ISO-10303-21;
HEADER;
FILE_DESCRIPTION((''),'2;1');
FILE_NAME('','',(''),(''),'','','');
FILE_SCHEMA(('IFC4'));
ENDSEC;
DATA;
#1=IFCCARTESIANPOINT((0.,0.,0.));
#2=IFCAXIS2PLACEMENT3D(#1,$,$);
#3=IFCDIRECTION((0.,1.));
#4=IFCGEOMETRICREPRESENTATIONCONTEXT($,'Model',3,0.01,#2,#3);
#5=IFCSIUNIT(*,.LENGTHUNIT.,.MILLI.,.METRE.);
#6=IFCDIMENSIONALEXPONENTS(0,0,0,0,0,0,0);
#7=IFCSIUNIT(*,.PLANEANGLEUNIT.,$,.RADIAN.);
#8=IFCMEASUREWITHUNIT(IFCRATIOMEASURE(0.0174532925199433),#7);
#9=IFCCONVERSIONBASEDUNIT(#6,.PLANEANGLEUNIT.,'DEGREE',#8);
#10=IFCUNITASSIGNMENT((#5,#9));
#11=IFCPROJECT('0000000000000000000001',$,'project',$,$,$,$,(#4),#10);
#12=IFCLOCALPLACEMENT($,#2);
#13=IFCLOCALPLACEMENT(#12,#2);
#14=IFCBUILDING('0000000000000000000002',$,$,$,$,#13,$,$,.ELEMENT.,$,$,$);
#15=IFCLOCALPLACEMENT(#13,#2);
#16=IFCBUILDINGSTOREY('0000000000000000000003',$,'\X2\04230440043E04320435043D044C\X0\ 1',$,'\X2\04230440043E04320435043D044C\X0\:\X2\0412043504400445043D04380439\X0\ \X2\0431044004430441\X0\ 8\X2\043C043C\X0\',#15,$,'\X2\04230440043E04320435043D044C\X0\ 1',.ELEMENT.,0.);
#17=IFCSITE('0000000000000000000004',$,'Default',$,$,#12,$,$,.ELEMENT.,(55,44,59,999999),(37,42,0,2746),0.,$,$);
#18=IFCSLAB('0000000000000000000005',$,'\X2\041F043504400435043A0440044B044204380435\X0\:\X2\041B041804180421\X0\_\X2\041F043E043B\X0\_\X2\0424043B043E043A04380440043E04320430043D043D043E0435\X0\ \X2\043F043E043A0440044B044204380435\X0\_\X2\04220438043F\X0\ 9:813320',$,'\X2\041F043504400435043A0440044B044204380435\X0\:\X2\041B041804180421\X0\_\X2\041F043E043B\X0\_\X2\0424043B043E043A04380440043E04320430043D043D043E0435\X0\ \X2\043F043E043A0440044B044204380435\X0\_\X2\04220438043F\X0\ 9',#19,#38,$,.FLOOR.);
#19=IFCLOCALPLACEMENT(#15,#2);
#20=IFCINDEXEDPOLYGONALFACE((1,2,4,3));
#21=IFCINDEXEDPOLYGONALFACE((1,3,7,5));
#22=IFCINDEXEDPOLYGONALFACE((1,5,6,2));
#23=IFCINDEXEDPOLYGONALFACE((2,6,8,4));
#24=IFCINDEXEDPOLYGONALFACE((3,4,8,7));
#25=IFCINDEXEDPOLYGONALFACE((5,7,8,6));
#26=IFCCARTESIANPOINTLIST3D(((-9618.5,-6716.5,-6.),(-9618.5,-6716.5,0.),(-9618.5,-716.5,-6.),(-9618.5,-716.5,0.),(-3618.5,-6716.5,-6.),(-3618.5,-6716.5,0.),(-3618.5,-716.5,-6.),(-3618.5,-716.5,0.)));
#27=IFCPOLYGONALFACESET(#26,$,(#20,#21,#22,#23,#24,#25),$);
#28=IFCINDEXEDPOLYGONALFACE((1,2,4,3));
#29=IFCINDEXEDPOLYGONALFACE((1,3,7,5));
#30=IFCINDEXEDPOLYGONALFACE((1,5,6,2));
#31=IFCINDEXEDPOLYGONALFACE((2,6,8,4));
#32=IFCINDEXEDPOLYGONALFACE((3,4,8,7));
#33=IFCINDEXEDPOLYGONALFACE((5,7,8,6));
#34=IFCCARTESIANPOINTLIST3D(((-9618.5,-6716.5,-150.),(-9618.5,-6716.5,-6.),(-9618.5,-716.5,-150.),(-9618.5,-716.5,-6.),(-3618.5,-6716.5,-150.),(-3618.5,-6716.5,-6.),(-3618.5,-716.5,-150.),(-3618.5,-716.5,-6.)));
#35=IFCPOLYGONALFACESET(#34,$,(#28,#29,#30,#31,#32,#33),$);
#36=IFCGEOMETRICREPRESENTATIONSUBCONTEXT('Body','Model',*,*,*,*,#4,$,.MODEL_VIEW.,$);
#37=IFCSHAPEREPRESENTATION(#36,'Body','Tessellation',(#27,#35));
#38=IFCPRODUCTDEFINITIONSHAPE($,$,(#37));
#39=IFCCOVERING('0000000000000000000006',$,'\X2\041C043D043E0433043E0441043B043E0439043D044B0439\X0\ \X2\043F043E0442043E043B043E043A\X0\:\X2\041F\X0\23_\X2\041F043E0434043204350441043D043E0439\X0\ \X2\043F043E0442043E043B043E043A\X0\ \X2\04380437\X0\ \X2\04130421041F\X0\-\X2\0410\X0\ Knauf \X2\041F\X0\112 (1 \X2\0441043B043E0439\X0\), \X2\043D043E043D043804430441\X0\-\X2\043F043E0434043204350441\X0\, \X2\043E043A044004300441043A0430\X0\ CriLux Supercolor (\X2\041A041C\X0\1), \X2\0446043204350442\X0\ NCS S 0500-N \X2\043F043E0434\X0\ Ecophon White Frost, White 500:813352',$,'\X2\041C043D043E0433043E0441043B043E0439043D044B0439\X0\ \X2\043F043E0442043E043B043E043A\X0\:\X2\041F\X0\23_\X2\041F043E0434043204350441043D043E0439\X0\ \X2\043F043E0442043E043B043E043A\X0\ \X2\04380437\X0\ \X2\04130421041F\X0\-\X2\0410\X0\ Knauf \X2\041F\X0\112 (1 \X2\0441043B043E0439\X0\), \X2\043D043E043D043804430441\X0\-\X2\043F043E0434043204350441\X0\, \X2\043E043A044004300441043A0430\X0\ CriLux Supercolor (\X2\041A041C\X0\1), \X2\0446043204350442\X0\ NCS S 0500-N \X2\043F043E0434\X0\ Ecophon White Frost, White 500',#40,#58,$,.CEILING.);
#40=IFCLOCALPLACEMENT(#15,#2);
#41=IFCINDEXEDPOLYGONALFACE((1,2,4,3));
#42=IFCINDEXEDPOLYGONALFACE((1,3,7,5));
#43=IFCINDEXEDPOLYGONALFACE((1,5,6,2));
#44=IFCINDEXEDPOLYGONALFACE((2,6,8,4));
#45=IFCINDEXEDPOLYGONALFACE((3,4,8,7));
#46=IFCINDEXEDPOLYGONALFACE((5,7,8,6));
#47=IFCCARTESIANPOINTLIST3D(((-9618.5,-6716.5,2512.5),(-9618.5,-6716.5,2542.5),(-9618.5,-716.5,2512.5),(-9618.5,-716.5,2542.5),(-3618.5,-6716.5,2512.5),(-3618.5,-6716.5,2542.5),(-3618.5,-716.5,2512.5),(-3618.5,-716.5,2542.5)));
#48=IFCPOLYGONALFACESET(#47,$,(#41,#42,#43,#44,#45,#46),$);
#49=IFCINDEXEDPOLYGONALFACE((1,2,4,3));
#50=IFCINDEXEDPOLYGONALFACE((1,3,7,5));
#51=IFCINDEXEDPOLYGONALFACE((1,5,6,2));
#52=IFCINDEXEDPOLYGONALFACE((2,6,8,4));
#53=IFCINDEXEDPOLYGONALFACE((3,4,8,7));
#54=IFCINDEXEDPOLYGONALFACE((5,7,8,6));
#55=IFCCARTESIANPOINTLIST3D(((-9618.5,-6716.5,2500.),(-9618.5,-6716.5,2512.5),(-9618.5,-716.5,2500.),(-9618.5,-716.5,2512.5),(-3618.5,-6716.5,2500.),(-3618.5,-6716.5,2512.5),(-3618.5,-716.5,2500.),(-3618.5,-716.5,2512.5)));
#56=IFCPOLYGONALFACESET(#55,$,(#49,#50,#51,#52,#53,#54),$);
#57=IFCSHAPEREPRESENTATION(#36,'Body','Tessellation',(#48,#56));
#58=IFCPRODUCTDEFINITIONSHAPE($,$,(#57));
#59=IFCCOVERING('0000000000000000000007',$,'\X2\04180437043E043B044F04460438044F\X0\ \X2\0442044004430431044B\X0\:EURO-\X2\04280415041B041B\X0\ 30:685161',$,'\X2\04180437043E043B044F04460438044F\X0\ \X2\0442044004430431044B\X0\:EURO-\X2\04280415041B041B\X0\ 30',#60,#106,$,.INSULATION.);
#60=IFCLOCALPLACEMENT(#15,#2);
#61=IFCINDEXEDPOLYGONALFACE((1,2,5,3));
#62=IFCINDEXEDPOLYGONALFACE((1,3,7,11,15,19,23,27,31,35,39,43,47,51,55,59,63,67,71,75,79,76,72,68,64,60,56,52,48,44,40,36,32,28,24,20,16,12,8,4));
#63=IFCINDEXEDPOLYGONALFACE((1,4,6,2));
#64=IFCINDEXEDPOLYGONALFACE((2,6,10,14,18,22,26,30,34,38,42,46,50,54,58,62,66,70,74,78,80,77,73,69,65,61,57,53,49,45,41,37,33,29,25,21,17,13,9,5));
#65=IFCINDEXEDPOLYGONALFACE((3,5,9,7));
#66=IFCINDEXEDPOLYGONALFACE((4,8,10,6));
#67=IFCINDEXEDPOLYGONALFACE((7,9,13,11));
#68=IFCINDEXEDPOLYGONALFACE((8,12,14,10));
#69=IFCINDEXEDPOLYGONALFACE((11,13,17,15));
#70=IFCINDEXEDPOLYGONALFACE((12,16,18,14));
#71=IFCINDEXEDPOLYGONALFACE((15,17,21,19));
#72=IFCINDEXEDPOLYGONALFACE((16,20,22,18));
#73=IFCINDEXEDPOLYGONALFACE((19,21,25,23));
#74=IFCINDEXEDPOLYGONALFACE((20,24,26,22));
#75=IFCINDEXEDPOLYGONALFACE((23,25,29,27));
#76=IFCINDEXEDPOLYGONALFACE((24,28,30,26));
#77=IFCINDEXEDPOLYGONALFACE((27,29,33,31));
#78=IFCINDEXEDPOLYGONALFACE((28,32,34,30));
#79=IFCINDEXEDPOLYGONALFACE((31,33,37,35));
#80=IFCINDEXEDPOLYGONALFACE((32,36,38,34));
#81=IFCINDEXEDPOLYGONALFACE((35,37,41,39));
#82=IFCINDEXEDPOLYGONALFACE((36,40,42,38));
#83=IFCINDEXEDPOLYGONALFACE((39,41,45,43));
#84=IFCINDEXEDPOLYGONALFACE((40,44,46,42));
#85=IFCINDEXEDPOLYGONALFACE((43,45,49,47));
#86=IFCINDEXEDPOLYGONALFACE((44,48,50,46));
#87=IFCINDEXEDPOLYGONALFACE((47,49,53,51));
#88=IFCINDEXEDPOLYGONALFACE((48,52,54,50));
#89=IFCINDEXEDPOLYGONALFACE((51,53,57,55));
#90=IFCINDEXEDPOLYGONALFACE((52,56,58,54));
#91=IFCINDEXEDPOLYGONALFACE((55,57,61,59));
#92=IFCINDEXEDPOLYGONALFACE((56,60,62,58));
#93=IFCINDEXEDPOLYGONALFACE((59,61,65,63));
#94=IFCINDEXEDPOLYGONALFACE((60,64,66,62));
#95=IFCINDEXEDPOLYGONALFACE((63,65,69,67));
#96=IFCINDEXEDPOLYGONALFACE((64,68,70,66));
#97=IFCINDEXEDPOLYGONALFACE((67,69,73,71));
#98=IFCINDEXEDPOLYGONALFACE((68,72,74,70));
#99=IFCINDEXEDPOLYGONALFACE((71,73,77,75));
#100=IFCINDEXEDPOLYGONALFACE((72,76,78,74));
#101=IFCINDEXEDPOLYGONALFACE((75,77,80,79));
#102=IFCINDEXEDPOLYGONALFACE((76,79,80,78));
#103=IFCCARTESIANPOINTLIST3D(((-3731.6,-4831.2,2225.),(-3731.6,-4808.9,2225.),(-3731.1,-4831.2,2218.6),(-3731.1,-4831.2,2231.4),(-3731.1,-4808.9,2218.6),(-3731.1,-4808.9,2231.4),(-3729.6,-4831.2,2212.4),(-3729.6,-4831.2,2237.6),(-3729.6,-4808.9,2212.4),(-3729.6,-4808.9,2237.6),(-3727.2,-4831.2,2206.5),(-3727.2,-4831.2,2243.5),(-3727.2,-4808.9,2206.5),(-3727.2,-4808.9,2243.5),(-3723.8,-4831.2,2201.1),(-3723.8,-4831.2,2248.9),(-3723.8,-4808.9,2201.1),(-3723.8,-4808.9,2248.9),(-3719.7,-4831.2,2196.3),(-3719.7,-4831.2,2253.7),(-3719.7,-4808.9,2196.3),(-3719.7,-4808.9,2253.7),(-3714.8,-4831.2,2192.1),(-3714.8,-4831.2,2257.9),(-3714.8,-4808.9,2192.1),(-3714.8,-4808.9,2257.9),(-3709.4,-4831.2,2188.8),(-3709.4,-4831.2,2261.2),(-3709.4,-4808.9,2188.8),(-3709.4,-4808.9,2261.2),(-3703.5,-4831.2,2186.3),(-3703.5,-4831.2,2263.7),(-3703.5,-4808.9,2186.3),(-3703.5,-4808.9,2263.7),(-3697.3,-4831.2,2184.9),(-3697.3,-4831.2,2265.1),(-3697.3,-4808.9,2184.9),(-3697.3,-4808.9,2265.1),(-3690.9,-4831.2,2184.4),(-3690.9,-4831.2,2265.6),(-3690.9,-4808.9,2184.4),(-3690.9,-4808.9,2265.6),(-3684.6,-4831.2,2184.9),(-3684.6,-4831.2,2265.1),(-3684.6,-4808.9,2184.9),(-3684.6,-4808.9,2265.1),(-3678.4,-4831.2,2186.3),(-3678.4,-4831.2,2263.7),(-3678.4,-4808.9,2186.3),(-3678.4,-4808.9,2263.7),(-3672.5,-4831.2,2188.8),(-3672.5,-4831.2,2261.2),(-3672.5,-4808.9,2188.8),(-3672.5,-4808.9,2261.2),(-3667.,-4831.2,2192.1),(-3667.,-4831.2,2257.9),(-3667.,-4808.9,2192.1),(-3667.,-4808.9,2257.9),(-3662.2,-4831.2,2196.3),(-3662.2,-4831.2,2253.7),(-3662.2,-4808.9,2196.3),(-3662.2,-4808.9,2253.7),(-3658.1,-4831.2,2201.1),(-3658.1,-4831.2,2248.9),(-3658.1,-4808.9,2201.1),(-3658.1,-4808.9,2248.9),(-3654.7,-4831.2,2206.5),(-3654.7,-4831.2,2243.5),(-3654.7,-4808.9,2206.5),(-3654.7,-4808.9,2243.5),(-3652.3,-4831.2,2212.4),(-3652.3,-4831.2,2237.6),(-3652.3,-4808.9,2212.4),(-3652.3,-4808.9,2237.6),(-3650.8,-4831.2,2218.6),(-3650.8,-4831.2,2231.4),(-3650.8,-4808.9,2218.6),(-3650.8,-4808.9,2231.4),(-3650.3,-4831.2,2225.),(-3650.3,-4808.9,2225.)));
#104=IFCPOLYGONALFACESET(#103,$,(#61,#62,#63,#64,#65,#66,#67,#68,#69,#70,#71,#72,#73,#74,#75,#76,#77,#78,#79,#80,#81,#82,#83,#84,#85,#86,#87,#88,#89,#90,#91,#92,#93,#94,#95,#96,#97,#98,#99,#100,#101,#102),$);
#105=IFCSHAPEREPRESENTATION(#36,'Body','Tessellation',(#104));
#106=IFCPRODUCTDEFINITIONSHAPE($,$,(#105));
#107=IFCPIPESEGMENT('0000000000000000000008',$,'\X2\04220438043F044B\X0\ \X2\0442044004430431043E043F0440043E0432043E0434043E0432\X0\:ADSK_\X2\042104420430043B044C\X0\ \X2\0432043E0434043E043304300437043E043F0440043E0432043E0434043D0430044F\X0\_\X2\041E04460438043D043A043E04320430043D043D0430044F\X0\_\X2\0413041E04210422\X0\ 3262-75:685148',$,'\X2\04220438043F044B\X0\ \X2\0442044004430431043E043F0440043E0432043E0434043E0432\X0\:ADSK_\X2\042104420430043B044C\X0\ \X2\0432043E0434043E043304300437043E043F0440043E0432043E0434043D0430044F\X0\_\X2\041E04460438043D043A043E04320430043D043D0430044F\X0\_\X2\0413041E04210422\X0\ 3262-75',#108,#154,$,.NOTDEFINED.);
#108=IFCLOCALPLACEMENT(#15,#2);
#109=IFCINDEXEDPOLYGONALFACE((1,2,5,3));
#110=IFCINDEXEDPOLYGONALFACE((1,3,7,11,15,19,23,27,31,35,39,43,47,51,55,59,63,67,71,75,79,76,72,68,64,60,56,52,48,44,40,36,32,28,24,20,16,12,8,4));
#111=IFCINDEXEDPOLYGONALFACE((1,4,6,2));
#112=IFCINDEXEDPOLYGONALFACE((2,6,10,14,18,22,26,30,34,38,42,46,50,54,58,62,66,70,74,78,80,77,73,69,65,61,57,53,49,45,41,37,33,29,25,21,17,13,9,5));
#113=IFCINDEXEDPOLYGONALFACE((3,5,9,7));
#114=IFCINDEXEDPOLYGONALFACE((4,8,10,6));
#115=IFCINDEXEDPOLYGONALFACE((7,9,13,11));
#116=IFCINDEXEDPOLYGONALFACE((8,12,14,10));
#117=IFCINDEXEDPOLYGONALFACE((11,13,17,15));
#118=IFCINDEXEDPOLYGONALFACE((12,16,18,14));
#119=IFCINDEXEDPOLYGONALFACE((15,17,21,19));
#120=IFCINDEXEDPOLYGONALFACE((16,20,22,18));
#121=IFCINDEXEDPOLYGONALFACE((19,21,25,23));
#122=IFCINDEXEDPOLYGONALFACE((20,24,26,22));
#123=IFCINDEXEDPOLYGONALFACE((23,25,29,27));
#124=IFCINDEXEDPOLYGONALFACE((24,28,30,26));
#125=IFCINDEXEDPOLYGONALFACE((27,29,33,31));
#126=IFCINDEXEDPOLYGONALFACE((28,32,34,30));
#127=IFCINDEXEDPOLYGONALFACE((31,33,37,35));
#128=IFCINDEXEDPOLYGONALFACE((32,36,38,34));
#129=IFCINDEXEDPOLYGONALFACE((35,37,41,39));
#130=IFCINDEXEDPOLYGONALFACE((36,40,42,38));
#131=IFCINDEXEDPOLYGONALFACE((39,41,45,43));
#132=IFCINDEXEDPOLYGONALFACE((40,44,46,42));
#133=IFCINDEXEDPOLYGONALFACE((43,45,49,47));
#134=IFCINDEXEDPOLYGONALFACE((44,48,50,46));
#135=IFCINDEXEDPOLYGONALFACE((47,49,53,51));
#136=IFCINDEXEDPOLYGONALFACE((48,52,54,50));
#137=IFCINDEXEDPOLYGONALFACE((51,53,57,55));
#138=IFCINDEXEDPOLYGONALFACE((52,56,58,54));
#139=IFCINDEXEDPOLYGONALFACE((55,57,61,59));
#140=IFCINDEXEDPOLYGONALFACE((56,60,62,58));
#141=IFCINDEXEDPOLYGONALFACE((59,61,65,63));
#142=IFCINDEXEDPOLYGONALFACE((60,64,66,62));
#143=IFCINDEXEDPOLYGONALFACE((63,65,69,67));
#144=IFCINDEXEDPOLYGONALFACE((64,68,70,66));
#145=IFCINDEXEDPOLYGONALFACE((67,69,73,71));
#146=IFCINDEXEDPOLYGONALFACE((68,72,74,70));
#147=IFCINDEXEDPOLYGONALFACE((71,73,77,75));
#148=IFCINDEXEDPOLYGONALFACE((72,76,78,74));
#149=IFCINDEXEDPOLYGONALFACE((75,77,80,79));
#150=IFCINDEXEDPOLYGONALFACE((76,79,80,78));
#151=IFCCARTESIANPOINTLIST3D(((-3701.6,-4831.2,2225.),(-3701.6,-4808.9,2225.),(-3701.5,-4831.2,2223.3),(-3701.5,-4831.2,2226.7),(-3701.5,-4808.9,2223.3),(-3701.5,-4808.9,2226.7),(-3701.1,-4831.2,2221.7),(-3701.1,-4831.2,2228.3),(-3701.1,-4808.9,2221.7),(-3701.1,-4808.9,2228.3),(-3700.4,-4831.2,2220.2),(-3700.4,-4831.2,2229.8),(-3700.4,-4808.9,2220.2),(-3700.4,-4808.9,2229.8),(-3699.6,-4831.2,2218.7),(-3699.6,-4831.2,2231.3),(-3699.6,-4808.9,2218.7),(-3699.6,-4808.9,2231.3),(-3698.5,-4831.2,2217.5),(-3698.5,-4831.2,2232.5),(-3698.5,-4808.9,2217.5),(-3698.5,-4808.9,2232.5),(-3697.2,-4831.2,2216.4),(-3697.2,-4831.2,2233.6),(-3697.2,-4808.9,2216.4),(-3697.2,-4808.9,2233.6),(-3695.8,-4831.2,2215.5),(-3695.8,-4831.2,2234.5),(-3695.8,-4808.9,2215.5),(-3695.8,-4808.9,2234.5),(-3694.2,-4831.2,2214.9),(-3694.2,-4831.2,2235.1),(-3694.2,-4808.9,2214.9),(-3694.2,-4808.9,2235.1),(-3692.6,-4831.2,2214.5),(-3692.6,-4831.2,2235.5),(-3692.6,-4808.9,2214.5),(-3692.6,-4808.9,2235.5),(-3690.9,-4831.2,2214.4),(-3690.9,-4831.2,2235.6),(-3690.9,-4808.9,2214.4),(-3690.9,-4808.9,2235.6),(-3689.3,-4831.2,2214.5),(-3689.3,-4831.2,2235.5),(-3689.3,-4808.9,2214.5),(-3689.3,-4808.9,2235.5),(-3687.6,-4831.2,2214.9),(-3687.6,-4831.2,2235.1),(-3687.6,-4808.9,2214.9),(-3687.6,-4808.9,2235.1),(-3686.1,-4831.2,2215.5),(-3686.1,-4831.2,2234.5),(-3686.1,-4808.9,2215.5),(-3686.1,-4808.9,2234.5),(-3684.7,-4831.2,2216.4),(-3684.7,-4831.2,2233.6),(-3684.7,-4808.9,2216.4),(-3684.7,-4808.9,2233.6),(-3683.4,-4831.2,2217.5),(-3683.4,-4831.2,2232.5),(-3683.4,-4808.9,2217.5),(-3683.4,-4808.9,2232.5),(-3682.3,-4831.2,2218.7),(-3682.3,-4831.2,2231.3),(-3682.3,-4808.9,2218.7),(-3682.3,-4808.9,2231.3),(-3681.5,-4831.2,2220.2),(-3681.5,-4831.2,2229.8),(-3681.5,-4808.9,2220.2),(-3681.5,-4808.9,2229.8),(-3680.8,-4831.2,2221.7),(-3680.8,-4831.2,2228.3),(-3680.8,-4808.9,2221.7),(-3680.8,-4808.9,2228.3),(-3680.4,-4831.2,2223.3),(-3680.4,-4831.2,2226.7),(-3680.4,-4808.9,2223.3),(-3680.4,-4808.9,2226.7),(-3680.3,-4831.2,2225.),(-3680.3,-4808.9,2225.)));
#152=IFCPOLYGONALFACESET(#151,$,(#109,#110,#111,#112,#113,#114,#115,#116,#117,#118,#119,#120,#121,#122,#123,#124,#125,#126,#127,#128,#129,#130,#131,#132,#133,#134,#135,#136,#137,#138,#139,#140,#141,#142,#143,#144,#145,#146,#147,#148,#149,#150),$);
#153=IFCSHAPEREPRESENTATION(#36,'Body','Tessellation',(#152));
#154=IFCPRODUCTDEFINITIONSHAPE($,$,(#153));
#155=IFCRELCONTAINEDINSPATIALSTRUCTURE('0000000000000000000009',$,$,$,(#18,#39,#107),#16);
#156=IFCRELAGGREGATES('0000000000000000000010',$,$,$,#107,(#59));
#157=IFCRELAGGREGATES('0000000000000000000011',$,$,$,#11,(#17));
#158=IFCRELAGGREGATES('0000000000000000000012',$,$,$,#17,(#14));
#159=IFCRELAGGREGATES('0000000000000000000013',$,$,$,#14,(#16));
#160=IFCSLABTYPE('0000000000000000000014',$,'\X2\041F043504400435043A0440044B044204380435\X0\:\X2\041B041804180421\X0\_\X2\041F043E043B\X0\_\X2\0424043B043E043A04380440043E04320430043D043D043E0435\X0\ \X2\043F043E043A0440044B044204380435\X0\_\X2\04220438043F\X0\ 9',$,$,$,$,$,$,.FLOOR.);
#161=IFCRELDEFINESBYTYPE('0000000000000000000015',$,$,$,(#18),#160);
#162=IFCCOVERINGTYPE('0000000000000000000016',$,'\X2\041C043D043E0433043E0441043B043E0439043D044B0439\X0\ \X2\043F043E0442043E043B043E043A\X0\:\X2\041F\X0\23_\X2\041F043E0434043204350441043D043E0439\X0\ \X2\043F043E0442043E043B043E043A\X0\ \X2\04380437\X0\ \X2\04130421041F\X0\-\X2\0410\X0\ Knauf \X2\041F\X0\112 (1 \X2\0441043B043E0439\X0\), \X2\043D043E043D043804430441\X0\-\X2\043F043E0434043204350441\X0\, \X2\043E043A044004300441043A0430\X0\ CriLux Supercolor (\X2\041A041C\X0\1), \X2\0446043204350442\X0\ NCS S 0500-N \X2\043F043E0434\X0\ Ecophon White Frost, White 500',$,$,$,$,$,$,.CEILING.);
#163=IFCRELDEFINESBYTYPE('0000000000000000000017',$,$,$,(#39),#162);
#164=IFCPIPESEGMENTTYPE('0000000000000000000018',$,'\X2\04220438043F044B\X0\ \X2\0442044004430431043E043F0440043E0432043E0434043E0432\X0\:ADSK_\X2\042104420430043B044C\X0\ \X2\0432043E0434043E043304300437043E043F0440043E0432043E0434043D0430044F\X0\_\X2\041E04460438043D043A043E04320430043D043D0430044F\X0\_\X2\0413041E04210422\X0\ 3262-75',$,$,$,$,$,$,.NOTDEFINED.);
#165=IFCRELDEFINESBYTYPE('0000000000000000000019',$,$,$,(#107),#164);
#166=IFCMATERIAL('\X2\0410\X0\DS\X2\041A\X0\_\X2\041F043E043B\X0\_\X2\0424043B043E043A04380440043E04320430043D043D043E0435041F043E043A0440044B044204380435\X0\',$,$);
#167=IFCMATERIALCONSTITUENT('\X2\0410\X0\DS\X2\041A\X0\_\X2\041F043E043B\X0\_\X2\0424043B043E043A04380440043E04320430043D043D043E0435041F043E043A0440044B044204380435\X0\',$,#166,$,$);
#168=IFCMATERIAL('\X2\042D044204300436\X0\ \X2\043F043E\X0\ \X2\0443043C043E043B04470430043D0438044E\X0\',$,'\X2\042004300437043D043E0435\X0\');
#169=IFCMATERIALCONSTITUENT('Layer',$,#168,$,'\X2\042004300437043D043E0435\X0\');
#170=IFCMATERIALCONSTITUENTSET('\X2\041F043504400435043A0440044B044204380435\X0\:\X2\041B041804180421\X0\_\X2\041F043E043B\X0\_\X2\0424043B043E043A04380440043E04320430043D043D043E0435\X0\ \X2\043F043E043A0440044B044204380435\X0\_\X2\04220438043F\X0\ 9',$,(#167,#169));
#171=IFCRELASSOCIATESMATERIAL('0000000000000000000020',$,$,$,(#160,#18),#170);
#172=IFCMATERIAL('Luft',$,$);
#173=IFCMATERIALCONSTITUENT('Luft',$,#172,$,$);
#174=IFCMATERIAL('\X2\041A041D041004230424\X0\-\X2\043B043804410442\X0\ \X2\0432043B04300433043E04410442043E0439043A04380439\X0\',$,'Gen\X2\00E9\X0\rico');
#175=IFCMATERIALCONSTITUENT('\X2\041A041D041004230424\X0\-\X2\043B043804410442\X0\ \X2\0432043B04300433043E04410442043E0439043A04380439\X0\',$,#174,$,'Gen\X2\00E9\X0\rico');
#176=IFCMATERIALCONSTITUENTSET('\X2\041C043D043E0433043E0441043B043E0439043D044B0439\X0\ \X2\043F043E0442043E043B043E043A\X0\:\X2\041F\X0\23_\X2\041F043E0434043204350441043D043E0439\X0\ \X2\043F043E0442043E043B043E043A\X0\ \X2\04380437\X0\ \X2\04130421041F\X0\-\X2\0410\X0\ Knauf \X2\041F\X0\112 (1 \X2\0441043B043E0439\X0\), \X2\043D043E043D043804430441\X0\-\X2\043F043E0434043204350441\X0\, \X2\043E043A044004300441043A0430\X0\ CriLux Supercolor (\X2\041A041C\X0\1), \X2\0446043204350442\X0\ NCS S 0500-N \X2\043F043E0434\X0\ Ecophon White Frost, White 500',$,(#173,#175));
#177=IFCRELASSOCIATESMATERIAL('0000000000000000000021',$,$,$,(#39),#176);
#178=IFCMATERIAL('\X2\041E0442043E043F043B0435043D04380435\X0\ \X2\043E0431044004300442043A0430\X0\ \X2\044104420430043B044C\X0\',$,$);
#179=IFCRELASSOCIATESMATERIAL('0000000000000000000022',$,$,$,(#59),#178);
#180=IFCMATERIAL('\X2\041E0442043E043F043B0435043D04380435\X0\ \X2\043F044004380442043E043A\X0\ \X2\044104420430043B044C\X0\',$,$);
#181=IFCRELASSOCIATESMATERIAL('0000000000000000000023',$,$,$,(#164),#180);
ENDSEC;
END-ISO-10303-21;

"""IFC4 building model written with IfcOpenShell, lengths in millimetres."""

from ifc_helpers import new_model, entity, si_unit, converted_unit, direction, frame, origin, place, context, subcontext, project, spatial, indexed_curve, outline, extrude, material, constituent, constituent_set, type_object, element, aggregate, save


model = new_model("IFC4")

# Units and contexts
model_context = context("Model", 3, precision=0.01, world=origin(), true_north=direction((0.0, 1.0)))
body_context = subcontext(model_context, "Body", "Model", "MODEL_VIEW")
ifc_project = project(units=[si_unit("LENGTHUNIT", "METRE", prefix="MILLI"), converted_unit("PLANEANGLEUNIT", "DEGREE", entity("IfcRatioMeasure", 0.0174532925199433), si_unit("PLANEANGLEUNIT", "RADIAN"), dimensions=[0, 0, 0, 0, 0, 0, 0])], contexts=[model_context])

# Site, building, storey
site_placement = place(None, origin())
site = spatial("IfcSite", under=ifc_project, at=site_placement, Name="Default", CompositionType="ELEMENT", RefLatitude=(55, 44, 59, 999999), RefLongitude=(37, 42, 0, 2746), RefElevation=0.0)
building_placement = place(site_placement, origin())
building = spatial("IfcBuilding", under=site, at=building_placement, CompositionType="ELEMENT")
storey_placement = place(building_placement, origin())
storey = spatial("IfcBuildingStorey", under=building, at=storey_placement, Name="Уровень 1", ObjectType="Уровень:Верхний брус 8мм", LongName="Уровень 1", CompositionType="ELEMENT", Elevation=0.0)

# Slab
ifc_material_1 = material(Name="АDSК_Пол_ФлокированноеПокрытие")
ifc_constituent_1 = constituent(ifc_material_1, Name="АDSК_Пол_ФлокированноеПокрытие")
ifc_material_2 = material(Name="Этаж по умолчанию", Category="Разное")
ifc_constituent_2 = constituent(ifc_material_2, Name="Layer", Category="Разное")
ifc_constituent_set_1 = constituent_set(constituents=[ifc_constituent_1, ifc_constituent_2], Name="Перекрытие:ЛИИС_Пол_Флокированное покрытие_Тип 9")
slab_type = type_object("IfcSlabType", Name="Перекрытие:ЛИИС_Пол_Флокированное покрытие_Тип 9", PredefinedType="FLOOR", material=ifc_constituent_set_1)
slab_placement = place(storey_placement, origin())
element("IfcSlab", 1, at=slab_placement, inside=storey, type_object=slab_type, material=ifc_constituent_set_1, Name="Перекрытие:ЛИИС_Пол_Флокированное покрытие_Тип 9:813320", ObjectType="Перекрытие:ЛИИС_Пол_Флокированное покрытие_Тип 9", PredefinedType="FLOOR", context=body_context, shape_type="SweptSolid", body=[
    extrude(outline(indexed_curve([(-3000.0, -3000.0), (3000.0, -3000.0), (3000.0, 3000.0), (-3000.0, 3000.0), (-3000.0, -3000.0)], self_intersect=False)), frame((-6618.5, -3716.5, -6.0), z_axis=(0.0, 0.0, 1.0), x_axis=(-1.0, 0.0, 0.0)), (0.0, 0.0, 1.0), 6.0),
    extrude(outline(indexed_curve([(-3000.0, -3000.0), (3000.0, -3000.0), (3000.0, 3000.0), (-3000.0, 3000.0), (-3000.0, -3000.0)], self_intersect=False)), frame((-6618.5, -3716.5, -150.0), z_axis=(0.0, 0.0, 1.0), x_axis=(-1.0, 0.0, 0.0)), (0.0, 0.0, 1.0), 144.0),
])

# Coverings
ifc_material_3 = material(Name="Luft")
ifc_constituent_3 = constituent(ifc_material_3, Name="Luft")
ifc_material_4 = material(Name="КНАУФ-лист влагостойкий", Category="Genérico")
ifc_constituent_4 = constituent(ifc_material_4, Name="КНАУФ-лист влагостойкий", Category="Genérico")
ifc_constituent_set_2 = constituent_set(constituents=[ifc_constituent_3, ifc_constituent_4], Name="Многослойный потолок:П23_Подвесной потолок из ГСП-А Knauf П112 (1 слой), нониус-подвес, окраска CriLux Supercolor (КМ1), цвет NCS S 0500-N под Ecophon White Frost, White 500")
covering_type = type_object("IfcCoveringType", Name="Многослойный потолок:П23_Подвесной потолок из ГСП-А Knauf П112 (1 слой), нониус-подвес, окраска CriLux Supercolor (КМ1), цвет NCS S 0500-N под Ecophon White Frost, White 500", PredefinedType="CEILING")
covering_1_placement = place(storey_placement, origin())
element("IfcCovering", 2, at=covering_1_placement, inside=storey, type_object=covering_type, material=ifc_constituent_set_2, Name="Многослойный потолок:П23_Подвесной потолок из ГСП-А Knauf П112 (1 слой), нониус-подвес, окраска CriLux Supercolor (КМ1), цвет NCS S 0500-N под Ecophon White Frost, White 500:813352", ObjectType="Многослойный потолок:П23_Подвесной потолок из ГСП-А Knauf П112 (1 слой), нониус-подвес, окраска CriLux Supercolor (КМ1), цвет NCS S 0500-N под Ecophon White Frost, White 500", PredefinedType="CEILING", context=body_context, shape_type="SweptSolid", body=[
    extrude(outline(indexed_curve([(-3000.0, -3000.0), (3000.0, -3000.0), (3000.0, 3000.0), (-3000.0, 3000.0), (-3000.0, -3000.0)], self_intersect=False)), frame((-6618.5, -3716.5, 2512.5)), (0.0, 0.0, 1.0), 30.0),
    extrude(outline(indexed_curve([(-3000.0, -3000.0), (3000.0, -3000.0), (3000.0, 3000.0), (-3000.0, 3000.0), (-3000.0, -3000.0)], self_intersect=False)), frame((-6618.5, -3716.5, 2500.0), z_axis=(0.0, 0.0, 1.0), x_axis=(0.0, -1.0, 0.0)), (0.0, 0.0, 1.0), 12.5),
])
ifc_material_5 = material(Name="Отопление обратка сталь")
covering_2_placement = place(storey_placement, origin())
covering_2 = element("IfcCovering", 3, at=covering_2_placement, material=ifc_material_5, Name="Изоляция трубы:EURO-ШЕЛЛ 30:685161", ObjectType="Изоляция трубы:EURO-ШЕЛЛ 30", PredefinedType="INSULATION", context=body_context, shape_type="SweptSolid", body=[
    extrude(outline(indexed_curve([(40.6, 0.0), (40.1, 6.4), (38.7, 12.6), (36.2, 18.5), (32.9, 23.9), (28.7, 28.7), (23.9, 32.9), (18.5, 36.2), (12.6, 38.7), (6.4, 40.1), (0.0, 40.6), (-6.4, 40.1), (-12.6, 38.7), (-18.5, 36.2), (-23.9, 32.9), (-28.7, 28.7), (-32.9, 23.9), (-36.2, 18.5), (-38.7, 12.6), (-40.1, 6.4), (-40.6, 0.0), (-40.1, -6.4), (-38.7, -12.6), (-36.2, -18.5), (-32.9, -23.9), (-28.7, -28.7), (-23.9, -32.9), (-18.5, -36.2), (-12.6, -38.7), (-6.4, -40.1), (0.0, -40.6), (6.4, -40.1), (12.6, -38.7), (18.5, -36.2), (23.9, -32.9), (28.7, -28.7), (32.9, -23.9), (36.2, -18.5), (38.7, -12.6), (40.1, -6.4), (40.6, 0.0)], self_intersect=False)), frame((-3690.9, -4831.2, 2225.0), z_axis=(0.0, 1.0, 0.0), x_axis=(-1.0, 0.0, 0.0)), (0.0, 0.0, 1.0), 22.3),
])
ifc_material_6 = material(Name="Отопление приток сталь")

# Pipe segment
pipe_segment_type_1 = type_object("IfcPipeSegmentType", Name="Типы трубопроводов:ADSK_Сталь водогазопроводная_Оцинкованная_ГОСТ 3262-75", PredefinedType="NOTDEFINED", material=ifc_material_6)
pipe_segment_1_placement = place(storey_placement, origin())
pipe_segment_1 = element("IfcPipeSegment", 4, at=pipe_segment_1_placement, inside=storey, type_object=pipe_segment_type_1, Name="Типы трубопроводов:ADSK_Сталь водогазопроводная_Оцинкованная_ГОСТ 3262-75:685148", ObjectType="Типы трубопроводов:ADSK_Сталь водогазопроводная_Оцинкованная_ГОСТ 3262-75", PredefinedType="NOTDEFINED", context=body_context, shape_type="SweptSolid", body=[
    extrude(outline(indexed_curve([(10.6, 0.0), (10.5, 1.7), (10.1, 3.3), (9.5, 4.8), (8.6, 6.3), (7.5, 7.5), (6.3, 8.6), (4.8, 9.5), (3.3, 10.1), (1.7, 10.5), (0.0, 10.7), (-1.7, 10.5), (-3.3, 10.1), (-4.8, 9.5), (-6.3, 8.6), (-7.5, 7.5), (-8.6, 6.3), (-9.5, 4.8), (-10.1, 3.3), (-10.5, 1.7), (-10.6, 0.0), (-10.5, -1.7), (-10.1, -3.3), (-9.5, -4.8), (-8.6, -6.3), (-7.5, -7.5), (-6.3, -8.6), (-4.8, -9.5), (-3.3, -10.1), (-1.7, -10.5), (0.0, -10.7), (1.7, -10.5), (3.3, -10.1), (4.8, -9.5), (6.3, -8.6), (7.5, -7.5), (8.6, -6.3), (9.5, -4.8), (10.1, -3.3), (10.5, -1.7), (10.6, 0.0)], self_intersect=False)), frame((-3690.9, -4831.2, 2225.0), z_axis=(0.0, 1.0, 0.0), x_axis=(1.0, 0.0, 0.0)), (0.0, 0.0, 1.0), 22.3),
])
aggregate(pipe_segment_1, [covering_2])

save(model, "model.ifc")
